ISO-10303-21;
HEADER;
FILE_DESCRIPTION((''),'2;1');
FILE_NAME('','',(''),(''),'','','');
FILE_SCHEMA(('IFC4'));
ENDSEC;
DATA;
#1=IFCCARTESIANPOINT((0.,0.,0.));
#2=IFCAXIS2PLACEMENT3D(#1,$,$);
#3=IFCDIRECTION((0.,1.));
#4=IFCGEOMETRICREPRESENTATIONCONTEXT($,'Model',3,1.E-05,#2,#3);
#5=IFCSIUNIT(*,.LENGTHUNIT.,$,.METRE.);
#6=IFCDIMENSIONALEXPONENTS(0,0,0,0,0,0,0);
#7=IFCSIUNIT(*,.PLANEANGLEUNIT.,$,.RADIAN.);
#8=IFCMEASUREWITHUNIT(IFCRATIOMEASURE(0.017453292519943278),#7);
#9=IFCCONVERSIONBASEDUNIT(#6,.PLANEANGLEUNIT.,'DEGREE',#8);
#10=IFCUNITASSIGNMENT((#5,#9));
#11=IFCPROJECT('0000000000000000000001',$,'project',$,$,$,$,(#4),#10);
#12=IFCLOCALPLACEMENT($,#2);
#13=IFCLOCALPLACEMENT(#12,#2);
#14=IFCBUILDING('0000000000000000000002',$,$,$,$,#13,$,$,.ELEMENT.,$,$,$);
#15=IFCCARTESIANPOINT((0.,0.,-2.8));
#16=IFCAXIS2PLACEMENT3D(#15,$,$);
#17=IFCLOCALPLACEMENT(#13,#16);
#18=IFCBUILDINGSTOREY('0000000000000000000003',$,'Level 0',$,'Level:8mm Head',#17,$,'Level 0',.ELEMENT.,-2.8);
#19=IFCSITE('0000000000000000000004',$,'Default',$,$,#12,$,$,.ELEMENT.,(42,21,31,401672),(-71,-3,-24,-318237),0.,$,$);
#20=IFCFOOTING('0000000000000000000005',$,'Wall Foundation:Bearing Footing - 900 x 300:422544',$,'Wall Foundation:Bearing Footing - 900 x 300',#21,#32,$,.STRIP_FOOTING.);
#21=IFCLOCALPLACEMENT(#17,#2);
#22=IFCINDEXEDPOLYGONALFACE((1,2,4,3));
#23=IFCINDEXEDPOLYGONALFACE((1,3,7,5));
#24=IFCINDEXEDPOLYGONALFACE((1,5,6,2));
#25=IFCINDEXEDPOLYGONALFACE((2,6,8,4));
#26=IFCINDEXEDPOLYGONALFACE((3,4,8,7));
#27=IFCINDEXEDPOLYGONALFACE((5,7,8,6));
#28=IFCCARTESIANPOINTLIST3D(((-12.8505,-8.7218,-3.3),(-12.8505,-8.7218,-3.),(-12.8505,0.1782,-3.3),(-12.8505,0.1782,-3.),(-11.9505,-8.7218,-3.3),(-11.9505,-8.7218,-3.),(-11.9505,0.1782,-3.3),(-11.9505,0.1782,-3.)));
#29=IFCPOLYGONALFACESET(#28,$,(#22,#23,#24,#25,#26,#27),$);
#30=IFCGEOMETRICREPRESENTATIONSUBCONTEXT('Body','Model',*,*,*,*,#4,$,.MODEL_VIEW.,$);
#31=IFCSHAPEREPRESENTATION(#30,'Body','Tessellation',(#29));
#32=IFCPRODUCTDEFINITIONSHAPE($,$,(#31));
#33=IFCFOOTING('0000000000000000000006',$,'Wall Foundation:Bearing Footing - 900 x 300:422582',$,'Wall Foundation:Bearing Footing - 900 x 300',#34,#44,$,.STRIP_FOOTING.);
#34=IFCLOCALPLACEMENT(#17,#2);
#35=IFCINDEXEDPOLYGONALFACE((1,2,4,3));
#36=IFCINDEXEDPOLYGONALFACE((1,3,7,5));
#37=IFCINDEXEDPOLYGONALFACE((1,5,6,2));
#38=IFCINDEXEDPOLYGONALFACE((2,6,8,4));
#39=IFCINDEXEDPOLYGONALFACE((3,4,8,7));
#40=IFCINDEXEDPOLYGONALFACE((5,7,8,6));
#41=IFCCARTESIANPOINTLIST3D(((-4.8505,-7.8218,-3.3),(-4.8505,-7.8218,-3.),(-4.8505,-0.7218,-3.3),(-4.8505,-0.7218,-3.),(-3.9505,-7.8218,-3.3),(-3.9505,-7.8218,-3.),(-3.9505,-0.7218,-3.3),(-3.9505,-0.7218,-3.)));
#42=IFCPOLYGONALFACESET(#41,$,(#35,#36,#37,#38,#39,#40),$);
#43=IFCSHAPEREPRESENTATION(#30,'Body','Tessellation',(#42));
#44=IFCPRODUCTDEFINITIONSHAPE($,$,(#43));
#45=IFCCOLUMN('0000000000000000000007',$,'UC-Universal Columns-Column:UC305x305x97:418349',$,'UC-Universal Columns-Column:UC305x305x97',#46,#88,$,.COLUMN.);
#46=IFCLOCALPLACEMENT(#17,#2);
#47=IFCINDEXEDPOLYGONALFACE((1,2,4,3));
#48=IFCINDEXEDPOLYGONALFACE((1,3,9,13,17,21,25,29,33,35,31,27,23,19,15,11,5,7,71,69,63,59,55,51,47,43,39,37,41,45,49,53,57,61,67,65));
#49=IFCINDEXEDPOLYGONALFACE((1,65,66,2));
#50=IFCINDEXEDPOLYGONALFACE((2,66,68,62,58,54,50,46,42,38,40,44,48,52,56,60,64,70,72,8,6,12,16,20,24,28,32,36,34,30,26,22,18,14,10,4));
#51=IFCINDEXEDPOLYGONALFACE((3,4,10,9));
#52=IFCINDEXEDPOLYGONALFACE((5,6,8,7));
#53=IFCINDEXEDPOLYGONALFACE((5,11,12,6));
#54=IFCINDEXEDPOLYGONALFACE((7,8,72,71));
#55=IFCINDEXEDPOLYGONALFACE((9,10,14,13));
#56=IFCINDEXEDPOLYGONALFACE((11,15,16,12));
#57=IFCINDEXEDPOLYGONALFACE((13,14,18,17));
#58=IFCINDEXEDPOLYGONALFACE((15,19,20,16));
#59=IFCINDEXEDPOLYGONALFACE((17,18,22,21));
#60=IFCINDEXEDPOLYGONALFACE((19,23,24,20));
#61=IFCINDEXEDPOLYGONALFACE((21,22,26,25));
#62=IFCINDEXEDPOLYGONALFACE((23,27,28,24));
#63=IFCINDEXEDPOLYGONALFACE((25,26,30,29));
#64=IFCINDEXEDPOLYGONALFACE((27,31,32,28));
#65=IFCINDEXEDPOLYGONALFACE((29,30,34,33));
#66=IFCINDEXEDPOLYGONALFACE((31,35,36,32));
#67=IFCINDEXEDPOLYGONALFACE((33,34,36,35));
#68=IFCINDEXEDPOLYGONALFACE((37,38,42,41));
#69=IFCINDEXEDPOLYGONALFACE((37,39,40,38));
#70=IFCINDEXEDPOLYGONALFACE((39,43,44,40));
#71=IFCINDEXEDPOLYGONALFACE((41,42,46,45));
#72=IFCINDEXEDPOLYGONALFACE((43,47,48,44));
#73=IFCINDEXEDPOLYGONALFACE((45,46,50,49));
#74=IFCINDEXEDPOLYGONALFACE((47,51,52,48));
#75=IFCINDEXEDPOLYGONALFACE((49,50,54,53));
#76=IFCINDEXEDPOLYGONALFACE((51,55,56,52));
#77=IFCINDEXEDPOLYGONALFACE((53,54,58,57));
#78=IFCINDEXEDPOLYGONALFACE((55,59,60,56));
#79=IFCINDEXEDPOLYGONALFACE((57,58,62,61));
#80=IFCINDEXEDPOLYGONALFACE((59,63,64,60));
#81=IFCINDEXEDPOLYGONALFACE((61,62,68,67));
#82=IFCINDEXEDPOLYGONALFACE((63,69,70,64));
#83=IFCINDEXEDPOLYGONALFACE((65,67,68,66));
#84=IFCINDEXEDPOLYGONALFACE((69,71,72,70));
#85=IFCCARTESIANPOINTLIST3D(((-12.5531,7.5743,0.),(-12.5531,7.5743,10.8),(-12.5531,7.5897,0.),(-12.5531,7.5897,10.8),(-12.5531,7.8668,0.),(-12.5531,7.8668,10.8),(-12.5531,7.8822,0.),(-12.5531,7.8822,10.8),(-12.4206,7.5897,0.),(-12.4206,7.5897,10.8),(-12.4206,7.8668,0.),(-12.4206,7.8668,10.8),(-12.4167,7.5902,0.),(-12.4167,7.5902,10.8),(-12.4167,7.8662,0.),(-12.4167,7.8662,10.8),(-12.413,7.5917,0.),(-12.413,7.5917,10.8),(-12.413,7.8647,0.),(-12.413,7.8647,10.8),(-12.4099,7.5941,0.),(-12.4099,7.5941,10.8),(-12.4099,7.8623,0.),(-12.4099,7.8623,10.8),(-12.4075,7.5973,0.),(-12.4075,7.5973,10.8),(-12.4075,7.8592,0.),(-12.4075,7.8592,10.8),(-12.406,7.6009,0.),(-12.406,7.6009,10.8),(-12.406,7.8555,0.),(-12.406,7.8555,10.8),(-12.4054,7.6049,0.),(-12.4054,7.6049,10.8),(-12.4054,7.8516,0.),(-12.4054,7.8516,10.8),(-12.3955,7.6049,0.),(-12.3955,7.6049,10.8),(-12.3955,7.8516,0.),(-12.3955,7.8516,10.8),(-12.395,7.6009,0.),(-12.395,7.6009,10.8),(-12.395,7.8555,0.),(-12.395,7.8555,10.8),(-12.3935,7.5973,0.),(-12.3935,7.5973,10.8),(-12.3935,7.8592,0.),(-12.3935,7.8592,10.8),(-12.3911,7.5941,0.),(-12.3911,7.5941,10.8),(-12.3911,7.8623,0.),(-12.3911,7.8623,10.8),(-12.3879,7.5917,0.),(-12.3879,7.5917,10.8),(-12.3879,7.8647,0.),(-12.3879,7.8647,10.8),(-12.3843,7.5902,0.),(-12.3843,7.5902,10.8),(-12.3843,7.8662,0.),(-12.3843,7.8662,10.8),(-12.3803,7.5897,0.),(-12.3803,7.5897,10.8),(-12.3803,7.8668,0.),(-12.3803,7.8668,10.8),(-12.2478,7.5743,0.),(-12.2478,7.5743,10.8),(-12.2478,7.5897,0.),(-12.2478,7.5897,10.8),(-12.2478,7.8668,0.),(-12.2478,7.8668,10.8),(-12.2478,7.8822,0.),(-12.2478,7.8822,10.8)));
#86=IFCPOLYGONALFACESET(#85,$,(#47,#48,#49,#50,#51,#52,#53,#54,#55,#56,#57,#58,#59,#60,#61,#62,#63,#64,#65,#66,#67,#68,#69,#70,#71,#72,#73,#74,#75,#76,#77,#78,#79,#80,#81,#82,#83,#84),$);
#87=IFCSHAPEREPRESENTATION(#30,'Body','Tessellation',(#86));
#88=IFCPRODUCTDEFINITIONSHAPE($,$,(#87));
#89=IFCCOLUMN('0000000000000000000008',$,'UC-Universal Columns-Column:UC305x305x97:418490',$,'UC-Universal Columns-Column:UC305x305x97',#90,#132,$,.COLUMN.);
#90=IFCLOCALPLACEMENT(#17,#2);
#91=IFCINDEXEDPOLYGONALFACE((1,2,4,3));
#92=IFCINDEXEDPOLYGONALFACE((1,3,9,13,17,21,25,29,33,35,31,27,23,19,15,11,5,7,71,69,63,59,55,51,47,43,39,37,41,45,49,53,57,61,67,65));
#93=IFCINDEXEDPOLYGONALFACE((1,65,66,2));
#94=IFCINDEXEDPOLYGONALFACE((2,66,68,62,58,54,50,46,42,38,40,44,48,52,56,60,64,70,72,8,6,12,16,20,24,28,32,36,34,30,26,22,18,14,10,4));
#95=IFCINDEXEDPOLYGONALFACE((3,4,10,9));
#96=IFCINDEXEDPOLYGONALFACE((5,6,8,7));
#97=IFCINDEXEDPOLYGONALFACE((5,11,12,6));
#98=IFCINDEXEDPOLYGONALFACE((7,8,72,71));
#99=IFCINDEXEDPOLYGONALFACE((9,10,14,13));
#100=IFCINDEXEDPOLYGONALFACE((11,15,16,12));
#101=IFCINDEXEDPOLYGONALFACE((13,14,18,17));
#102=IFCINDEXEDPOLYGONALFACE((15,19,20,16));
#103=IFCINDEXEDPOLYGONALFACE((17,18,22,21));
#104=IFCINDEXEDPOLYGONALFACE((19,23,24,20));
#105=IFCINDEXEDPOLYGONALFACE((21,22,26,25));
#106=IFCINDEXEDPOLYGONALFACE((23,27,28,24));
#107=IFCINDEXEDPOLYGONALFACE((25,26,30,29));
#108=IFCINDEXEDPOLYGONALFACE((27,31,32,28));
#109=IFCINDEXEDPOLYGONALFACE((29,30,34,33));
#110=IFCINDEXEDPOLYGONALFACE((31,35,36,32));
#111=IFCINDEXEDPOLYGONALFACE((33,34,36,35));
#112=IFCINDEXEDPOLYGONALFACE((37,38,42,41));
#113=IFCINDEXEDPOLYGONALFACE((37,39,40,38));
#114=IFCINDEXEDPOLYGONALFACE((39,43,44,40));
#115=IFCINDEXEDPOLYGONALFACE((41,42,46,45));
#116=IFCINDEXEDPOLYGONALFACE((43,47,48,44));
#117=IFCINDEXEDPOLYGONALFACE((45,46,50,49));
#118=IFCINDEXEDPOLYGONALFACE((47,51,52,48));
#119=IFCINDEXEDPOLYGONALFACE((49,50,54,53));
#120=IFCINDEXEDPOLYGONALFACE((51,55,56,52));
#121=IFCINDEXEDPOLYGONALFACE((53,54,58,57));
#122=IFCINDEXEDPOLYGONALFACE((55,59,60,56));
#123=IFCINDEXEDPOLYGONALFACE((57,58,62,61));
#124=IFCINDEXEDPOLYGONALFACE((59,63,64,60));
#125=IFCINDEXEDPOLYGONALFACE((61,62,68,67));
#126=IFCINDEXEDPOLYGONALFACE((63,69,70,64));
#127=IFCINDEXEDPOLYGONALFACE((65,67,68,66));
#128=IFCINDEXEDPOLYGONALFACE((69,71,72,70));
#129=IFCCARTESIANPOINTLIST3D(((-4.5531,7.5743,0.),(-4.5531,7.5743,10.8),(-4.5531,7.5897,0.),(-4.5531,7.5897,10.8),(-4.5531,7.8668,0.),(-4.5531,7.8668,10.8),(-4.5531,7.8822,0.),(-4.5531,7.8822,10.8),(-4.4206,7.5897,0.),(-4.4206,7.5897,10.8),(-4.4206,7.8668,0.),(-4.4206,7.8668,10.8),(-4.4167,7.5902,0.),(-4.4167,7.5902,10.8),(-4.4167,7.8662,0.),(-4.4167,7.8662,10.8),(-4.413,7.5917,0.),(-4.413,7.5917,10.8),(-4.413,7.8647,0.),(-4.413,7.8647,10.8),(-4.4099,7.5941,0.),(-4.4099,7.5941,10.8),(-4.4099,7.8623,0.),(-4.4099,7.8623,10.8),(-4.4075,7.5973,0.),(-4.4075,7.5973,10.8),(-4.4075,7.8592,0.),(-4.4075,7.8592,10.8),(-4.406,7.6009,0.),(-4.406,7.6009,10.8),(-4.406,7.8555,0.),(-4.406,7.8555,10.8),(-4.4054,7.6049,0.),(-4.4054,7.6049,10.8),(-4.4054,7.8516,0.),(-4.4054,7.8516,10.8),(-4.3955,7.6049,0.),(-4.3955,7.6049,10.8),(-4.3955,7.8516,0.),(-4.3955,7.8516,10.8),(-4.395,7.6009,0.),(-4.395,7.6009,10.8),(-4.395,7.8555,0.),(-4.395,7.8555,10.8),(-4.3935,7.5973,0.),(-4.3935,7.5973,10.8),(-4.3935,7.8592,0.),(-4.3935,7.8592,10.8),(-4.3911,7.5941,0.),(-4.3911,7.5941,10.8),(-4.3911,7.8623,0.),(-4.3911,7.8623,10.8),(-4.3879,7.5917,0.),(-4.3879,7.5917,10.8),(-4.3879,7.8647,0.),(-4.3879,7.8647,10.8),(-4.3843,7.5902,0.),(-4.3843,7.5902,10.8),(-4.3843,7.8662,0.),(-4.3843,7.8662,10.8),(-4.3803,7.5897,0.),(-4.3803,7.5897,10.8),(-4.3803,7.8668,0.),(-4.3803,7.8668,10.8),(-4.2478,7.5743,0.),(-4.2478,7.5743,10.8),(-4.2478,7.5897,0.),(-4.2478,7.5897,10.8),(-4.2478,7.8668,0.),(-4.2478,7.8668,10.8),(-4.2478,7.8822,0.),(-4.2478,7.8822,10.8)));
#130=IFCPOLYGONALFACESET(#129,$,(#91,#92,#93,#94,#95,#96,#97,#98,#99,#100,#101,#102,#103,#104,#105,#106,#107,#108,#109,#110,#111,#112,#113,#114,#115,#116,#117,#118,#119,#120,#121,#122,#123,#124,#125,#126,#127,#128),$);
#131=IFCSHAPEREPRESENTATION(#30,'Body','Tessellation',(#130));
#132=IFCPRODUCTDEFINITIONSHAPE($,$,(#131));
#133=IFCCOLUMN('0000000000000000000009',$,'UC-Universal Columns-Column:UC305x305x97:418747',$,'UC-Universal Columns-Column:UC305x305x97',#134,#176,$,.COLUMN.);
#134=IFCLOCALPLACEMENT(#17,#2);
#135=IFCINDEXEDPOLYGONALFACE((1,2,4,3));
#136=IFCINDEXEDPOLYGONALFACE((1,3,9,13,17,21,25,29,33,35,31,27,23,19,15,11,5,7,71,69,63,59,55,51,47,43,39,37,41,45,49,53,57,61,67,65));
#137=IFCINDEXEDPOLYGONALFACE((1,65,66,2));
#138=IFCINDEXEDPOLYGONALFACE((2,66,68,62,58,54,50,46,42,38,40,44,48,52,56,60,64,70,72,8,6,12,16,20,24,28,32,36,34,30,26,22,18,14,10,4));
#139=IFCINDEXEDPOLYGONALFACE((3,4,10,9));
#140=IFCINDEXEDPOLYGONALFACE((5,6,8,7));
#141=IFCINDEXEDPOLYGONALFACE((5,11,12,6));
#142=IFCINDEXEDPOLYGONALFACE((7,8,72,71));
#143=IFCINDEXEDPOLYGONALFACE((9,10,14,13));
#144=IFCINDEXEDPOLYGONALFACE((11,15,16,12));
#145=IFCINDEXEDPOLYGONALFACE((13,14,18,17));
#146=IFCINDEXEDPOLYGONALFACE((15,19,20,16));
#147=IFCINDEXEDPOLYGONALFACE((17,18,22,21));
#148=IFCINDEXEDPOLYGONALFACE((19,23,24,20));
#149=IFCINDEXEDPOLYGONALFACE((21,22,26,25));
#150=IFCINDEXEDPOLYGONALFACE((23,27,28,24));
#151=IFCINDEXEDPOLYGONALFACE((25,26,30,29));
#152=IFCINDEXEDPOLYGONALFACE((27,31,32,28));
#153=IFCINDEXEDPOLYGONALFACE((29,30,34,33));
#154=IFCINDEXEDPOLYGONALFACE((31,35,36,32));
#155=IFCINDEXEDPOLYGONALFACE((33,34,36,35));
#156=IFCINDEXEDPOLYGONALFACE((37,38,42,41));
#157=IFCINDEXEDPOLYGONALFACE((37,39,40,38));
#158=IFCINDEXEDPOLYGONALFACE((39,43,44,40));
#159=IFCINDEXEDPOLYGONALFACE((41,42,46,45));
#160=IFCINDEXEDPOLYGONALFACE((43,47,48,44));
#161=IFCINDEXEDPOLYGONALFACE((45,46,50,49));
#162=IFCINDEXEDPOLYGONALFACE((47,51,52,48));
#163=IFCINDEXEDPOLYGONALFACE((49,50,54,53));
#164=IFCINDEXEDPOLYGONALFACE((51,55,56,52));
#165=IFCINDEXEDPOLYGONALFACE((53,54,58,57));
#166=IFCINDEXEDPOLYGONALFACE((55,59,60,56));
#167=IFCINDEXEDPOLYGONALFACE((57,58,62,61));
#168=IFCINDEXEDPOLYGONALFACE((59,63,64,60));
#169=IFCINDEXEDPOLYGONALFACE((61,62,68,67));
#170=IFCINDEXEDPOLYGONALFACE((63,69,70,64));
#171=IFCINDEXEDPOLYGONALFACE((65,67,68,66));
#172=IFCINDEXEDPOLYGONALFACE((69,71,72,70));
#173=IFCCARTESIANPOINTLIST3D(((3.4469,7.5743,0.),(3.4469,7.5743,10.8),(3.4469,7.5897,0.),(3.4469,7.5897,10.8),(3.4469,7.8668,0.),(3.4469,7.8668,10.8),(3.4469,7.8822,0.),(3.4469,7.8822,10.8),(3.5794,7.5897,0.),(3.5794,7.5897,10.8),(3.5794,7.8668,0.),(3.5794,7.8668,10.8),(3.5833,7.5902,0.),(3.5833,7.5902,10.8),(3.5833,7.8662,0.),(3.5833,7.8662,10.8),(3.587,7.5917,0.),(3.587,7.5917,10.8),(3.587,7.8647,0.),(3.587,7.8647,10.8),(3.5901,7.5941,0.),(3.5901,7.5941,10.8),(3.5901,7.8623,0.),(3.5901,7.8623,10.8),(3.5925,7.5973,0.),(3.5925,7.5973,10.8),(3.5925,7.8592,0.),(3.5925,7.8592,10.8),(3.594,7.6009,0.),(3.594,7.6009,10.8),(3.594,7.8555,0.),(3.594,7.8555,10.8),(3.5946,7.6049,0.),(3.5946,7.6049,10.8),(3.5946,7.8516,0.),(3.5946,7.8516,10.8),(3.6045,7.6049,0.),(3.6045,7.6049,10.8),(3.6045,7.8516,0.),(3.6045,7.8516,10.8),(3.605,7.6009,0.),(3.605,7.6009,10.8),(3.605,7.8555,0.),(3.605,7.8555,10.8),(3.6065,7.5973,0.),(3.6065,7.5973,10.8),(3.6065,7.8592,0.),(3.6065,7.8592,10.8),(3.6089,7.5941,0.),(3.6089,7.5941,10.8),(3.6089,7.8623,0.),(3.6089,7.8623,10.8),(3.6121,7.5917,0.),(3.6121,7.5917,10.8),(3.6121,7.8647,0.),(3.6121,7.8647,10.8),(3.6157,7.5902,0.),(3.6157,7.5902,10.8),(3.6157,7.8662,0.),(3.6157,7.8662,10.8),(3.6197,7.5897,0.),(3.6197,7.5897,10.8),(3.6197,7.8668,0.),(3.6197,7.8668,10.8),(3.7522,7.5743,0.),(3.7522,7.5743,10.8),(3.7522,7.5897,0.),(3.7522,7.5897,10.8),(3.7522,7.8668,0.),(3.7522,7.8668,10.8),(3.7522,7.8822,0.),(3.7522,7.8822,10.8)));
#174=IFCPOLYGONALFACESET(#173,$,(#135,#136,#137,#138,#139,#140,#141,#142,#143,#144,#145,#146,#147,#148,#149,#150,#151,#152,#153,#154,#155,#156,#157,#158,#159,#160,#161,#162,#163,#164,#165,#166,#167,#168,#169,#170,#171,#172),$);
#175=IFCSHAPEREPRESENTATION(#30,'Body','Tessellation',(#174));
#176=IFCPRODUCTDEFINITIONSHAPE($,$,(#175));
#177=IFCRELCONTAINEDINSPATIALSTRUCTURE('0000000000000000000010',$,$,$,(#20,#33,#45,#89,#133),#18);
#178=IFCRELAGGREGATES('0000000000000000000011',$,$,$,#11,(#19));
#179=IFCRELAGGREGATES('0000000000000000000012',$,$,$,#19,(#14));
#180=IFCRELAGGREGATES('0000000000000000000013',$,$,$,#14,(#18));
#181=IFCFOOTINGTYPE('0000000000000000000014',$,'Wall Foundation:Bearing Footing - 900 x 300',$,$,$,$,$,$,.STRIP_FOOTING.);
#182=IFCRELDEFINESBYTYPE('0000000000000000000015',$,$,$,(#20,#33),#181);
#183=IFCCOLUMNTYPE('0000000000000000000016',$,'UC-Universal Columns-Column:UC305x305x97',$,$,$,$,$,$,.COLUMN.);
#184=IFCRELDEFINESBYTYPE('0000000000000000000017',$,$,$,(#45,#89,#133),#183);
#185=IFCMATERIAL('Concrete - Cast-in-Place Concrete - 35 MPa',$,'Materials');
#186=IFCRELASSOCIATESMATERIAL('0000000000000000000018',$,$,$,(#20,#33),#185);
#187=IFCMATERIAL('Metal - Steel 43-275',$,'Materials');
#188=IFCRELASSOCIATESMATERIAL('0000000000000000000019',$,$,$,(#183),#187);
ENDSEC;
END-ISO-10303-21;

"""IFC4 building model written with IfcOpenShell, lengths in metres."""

from ifc_helpers import new_model, entity, si_unit, converted_unit, direction, frame, frame_2d, origin, place, context, subcontext, project, spatial, rectangle, i_section, extrude, source, transform, mapped, material, material_profile, profile_set, type_object, type_shapes, element, save


model = new_model("IFC4")

# Units and contexts
model_context = context("Model", 3, precision=1e-05, world=origin(), true_north=direction((0.0, 1.0)))
body_context = subcontext(model_context, "Body", "Model", "MODEL_VIEW")
ifc_project = project(units=[si_unit("LENGTHUNIT", "METRE"), converted_unit("PLANEANGLEUNIT", "DEGREE", entity("IfcRatioMeasure", 0.017453292519943278), si_unit("PLANEANGLEUNIT", "RADIAN"), dimensions=[0, 0, 0, 0, 0, 0, 0])], contexts=[model_context])

# Site, building, storey
site_placement = place(None, origin())
site = spatial("IfcSite", under=ifc_project, at=site_placement, Name="Default", CompositionType="ELEMENT", RefLatitude=(42, 21, 31, 401672), RefLongitude=(-71, -3, -24, -318237), RefElevation=0.0)
building_placement = place(site_placement, origin())
building = spatial("IfcBuilding", under=site, at=building_placement, CompositionType="ELEMENT")
storey_placement = place(building_placement, frame((0.0, 0.0, -2.8)))
storey = spatial("IfcBuildingStorey", under=building, at=storey_placement, Name="Level 0", ObjectType="Level:8mm Head", LongName="Level 0", CompositionType="ELEMENT", Elevation=-2.8)

# Footings
ifc_material_1 = material(Name="Concrete - Cast-in-Place Concrete - 35 MPa", Category="Materials")
footing_type = type_object("IfcFootingType", Name="Wall Foundation:Bearing Footing - 900 x 300", PredefinedType="STRIP_FOOTING")
footing_1_placement = place(storey_placement, frame((-12.8505, -8.7218, -3.3)))
element("IfcFooting", 1, at=footing_1_placement, inside=storey, type_object=footing_type, material=ifc_material_1, Name="Wall Foundation:Bearing Footing - 900 x 300:422544", ObjectType="Wall Foundation:Bearing Footing - 900 x 300", PredefinedType="STRIP_FOOTING", context=body_context, shape_type="SweptSolid", body=[
    extrude(rectangle(XDim=8.9, YDim=0.9, at=frame_2d((0.0, 0.15), x_axis=(1.0, 0.0))), frame((0.6, 4.45, 0.0), z_axis=(0.0, 0.0, 1.0), x_axis=(0.0, 1.0, 0.0)), (0.0, 0.0, 1.0), 0.3),
])
footing_2_placement = place(storey_placement, frame((-4.8505, -7.8218, -3.3)))
element("IfcFooting", 2, at=footing_2_placement, inside=storey, type_object=footing_type, material=ifc_material_1, Name="Wall Foundation:Bearing Footing - 900 x 300:422582", ObjectType="Wall Foundation:Bearing Footing - 900 x 300", PredefinedType="STRIP_FOOTING", context=body_context, shape_type="SweptSolid", body=[
    extrude(rectangle(XDim=7.1, YDim=0.9, at=frame_2d((0.0, 0.0), x_axis=(1.0, 0.0))), frame((0.45, 3.55, 0.0), z_axis=(0.0, 0.0, 1.0), x_axis=(0.0, 1.0, 0.0)), (0.0, 0.0, 1.0), 0.3),
])

# Columns
ifc_material_2 = material(Name="Metal - Steel 43-275", Category="Materials")
ifc_material_profile = material_profile(ifc_material_2, i_section(OverallWidth=0.3053, OverallDepth=0.3079, WebThickness=0.0099, FlangeThickness=0.0154, FilletRadius=0.0152, at=frame_2d((0.0, 0.0), x_axis=(0.0, 1.0))), Name="UC305x305x97")
ifc_profile_set = profile_set([ifc_material_profile], Name="UC305x305x97")
column_type = type_object("IfcColumnType", Name="UC-Universal Columns-Column:UC305x305x97", PredefinedType="COLUMN", material=ifc_profile_set)
shared_shape = source(origin(), body_context, "Body", "SweptSolid", [
    extrude(i_section(OverallWidth=0.3053, OverallDepth=0.3079, WebThickness=0.0099, FlangeThickness=0.0154, FilletRadius=0.0152, at=frame_2d((0.0, 0.0), x_axis=(0.0, 1.0))), frame((0.0, 0.0, -2.8), z_axis=(0.0, 0.0, 1.0), x_axis=(0.0, -1.0, 0.0)), (0.0, 0.0, 1.0), 10.8),
])
type_shapes(column_type, [shared_shape])
for number, where, name in (
    (3, (-12.4005, 7.7282, 2.8), "UC-Universal Columns-Column:UC305x305x97:418349"),
    (4, (-4.4005, 7.7282, 2.8), "UC-Universal Columns-Column:UC305x305x97:418490"),
    (5, (3.5995, 7.7282, 2.8), "UC-Universal Columns-Column:UC305x305x97:418747"),
):
    element("IfcColumn", number, at=place(storey_placement, frame(where)), inside=storey, type_object=column_type, Name=name, ObjectType="UC-Universal Columns-Column:UC305x305x97", PredefinedType="COLUMN", context=body_context, shape_type="MappedRepresentation", body=[
        mapped(shared_shape, transform((0.0, 0.0, 0.0), scale=1.0)),
    ])

save(model, "model.ifc")
